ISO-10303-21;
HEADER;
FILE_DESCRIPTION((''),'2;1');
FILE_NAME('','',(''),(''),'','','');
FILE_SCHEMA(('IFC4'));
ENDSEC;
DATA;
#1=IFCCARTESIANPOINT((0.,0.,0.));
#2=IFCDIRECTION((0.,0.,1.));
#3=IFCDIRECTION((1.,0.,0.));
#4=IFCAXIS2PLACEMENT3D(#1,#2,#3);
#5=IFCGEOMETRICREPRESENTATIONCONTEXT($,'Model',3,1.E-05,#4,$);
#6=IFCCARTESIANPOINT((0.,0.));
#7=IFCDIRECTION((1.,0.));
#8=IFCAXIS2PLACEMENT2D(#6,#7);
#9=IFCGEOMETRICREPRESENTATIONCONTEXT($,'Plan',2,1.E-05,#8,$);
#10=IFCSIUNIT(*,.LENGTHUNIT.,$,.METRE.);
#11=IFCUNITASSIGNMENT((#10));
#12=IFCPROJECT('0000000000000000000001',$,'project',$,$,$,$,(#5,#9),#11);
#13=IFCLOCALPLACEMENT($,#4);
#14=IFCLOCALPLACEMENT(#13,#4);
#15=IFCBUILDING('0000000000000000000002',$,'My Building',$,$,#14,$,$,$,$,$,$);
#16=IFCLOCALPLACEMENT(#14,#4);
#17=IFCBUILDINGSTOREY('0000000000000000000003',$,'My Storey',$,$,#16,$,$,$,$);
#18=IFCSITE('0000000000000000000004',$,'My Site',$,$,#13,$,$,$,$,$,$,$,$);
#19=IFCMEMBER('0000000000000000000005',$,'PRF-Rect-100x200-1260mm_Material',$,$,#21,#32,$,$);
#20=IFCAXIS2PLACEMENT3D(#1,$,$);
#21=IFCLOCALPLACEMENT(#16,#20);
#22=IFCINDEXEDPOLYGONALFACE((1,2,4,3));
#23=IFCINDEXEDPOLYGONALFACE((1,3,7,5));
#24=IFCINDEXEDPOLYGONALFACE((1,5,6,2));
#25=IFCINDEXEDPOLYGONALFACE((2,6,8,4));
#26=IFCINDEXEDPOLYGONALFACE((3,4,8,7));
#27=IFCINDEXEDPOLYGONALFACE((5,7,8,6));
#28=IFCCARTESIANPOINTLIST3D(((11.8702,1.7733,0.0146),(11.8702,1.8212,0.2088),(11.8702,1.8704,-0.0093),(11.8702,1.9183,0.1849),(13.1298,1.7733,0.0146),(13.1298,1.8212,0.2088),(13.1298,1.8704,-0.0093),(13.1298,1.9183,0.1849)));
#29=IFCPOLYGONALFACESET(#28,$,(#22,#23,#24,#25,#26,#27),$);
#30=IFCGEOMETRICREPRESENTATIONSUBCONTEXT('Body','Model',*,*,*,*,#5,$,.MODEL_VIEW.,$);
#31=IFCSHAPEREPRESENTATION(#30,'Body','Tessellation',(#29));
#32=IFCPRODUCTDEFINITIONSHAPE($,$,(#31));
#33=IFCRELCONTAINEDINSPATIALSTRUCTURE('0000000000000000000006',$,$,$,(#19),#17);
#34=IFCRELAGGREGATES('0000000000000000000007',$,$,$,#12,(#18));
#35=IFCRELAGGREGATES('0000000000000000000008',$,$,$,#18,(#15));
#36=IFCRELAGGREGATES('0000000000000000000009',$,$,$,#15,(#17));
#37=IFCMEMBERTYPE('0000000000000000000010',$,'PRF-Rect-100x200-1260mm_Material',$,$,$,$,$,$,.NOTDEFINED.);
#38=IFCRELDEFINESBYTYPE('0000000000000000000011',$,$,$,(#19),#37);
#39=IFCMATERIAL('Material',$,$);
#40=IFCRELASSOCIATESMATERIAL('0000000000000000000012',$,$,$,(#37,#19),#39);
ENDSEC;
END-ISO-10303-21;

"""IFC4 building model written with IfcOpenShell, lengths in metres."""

from ifc_helpers import new_model, si_unit, frame, origin, origin_with_axes, origin_2d_with_axis, place, context, subcontext, project, spatial, rectangle, extrude, material, material_profile, profile_set, profile_usage, type_object, element, save


model = new_model("IFC4")

# Units and contexts
model_context = context("Model", 3, precision=1e-05, world=origin_with_axes())
plan_context = context("Plan", 2, precision=1e-05, world=origin_2d_with_axis())
body_context = subcontext(model_context, "Body", "Model", "MODEL_VIEW")
ifc_project = project(units=[si_unit("LENGTHUNIT", "METRE")], contexts=[model_context, plan_context])

# Site, building, storey
site_placement = place(None, origin_with_axes())
site = spatial("IfcSite", under=ifc_project, at=site_placement, Name="My Site")
building_placement = place(site_placement, origin_with_axes())
building = spatial("IfcBuilding", under=site, at=building_placement, Name="My Building")
storey_placement = place(building_placement, origin_with_axes())
storey = spatial("IfcBuildingStorey", under=building, at=storey_placement, Name="My Storey")

# Member
ifc_material = material(Name="Material")
ifc_material_profile_1 = material_profile(ifc_material, rectangle(XDim=0.1, YDim=0.2))
ifc_profile_set_1 = profile_set([ifc_material_profile_1], Name="PRF-Rect-100x200-1260mm_Material")
member_type_1 = type_object("IfcMemberType", Name="PRF-Rect-100x200-1260mm_Material", PredefinedType="NOTDEFINED", material=ifc_profile_set_1)
ifc_profile_usage_1 = profile_usage(ifc_profile_set_1, cardinal=5)
member_1_placement = place(storey_placement, frame((13.1298, 1.8458, 0.0998), z_axis=(-1.0, 0.0, 0.0), x_axis=(0.0, 0.970857, -0.239658)))
element("IfcMember", 1, at=member_1_placement, inside=storey, type_object=member_type_1, material=ifc_profile_usage_1, Name="PRF-Rect-100x200-1260mm_Material", context=body_context, shape_type="SweptSolid", body=[
    extrude(rectangle(XDim=0.1, YDim=0.2), origin(), (0.0, 0.0, 1.0), 1.2597),
])

save(model, "model.ifc")
